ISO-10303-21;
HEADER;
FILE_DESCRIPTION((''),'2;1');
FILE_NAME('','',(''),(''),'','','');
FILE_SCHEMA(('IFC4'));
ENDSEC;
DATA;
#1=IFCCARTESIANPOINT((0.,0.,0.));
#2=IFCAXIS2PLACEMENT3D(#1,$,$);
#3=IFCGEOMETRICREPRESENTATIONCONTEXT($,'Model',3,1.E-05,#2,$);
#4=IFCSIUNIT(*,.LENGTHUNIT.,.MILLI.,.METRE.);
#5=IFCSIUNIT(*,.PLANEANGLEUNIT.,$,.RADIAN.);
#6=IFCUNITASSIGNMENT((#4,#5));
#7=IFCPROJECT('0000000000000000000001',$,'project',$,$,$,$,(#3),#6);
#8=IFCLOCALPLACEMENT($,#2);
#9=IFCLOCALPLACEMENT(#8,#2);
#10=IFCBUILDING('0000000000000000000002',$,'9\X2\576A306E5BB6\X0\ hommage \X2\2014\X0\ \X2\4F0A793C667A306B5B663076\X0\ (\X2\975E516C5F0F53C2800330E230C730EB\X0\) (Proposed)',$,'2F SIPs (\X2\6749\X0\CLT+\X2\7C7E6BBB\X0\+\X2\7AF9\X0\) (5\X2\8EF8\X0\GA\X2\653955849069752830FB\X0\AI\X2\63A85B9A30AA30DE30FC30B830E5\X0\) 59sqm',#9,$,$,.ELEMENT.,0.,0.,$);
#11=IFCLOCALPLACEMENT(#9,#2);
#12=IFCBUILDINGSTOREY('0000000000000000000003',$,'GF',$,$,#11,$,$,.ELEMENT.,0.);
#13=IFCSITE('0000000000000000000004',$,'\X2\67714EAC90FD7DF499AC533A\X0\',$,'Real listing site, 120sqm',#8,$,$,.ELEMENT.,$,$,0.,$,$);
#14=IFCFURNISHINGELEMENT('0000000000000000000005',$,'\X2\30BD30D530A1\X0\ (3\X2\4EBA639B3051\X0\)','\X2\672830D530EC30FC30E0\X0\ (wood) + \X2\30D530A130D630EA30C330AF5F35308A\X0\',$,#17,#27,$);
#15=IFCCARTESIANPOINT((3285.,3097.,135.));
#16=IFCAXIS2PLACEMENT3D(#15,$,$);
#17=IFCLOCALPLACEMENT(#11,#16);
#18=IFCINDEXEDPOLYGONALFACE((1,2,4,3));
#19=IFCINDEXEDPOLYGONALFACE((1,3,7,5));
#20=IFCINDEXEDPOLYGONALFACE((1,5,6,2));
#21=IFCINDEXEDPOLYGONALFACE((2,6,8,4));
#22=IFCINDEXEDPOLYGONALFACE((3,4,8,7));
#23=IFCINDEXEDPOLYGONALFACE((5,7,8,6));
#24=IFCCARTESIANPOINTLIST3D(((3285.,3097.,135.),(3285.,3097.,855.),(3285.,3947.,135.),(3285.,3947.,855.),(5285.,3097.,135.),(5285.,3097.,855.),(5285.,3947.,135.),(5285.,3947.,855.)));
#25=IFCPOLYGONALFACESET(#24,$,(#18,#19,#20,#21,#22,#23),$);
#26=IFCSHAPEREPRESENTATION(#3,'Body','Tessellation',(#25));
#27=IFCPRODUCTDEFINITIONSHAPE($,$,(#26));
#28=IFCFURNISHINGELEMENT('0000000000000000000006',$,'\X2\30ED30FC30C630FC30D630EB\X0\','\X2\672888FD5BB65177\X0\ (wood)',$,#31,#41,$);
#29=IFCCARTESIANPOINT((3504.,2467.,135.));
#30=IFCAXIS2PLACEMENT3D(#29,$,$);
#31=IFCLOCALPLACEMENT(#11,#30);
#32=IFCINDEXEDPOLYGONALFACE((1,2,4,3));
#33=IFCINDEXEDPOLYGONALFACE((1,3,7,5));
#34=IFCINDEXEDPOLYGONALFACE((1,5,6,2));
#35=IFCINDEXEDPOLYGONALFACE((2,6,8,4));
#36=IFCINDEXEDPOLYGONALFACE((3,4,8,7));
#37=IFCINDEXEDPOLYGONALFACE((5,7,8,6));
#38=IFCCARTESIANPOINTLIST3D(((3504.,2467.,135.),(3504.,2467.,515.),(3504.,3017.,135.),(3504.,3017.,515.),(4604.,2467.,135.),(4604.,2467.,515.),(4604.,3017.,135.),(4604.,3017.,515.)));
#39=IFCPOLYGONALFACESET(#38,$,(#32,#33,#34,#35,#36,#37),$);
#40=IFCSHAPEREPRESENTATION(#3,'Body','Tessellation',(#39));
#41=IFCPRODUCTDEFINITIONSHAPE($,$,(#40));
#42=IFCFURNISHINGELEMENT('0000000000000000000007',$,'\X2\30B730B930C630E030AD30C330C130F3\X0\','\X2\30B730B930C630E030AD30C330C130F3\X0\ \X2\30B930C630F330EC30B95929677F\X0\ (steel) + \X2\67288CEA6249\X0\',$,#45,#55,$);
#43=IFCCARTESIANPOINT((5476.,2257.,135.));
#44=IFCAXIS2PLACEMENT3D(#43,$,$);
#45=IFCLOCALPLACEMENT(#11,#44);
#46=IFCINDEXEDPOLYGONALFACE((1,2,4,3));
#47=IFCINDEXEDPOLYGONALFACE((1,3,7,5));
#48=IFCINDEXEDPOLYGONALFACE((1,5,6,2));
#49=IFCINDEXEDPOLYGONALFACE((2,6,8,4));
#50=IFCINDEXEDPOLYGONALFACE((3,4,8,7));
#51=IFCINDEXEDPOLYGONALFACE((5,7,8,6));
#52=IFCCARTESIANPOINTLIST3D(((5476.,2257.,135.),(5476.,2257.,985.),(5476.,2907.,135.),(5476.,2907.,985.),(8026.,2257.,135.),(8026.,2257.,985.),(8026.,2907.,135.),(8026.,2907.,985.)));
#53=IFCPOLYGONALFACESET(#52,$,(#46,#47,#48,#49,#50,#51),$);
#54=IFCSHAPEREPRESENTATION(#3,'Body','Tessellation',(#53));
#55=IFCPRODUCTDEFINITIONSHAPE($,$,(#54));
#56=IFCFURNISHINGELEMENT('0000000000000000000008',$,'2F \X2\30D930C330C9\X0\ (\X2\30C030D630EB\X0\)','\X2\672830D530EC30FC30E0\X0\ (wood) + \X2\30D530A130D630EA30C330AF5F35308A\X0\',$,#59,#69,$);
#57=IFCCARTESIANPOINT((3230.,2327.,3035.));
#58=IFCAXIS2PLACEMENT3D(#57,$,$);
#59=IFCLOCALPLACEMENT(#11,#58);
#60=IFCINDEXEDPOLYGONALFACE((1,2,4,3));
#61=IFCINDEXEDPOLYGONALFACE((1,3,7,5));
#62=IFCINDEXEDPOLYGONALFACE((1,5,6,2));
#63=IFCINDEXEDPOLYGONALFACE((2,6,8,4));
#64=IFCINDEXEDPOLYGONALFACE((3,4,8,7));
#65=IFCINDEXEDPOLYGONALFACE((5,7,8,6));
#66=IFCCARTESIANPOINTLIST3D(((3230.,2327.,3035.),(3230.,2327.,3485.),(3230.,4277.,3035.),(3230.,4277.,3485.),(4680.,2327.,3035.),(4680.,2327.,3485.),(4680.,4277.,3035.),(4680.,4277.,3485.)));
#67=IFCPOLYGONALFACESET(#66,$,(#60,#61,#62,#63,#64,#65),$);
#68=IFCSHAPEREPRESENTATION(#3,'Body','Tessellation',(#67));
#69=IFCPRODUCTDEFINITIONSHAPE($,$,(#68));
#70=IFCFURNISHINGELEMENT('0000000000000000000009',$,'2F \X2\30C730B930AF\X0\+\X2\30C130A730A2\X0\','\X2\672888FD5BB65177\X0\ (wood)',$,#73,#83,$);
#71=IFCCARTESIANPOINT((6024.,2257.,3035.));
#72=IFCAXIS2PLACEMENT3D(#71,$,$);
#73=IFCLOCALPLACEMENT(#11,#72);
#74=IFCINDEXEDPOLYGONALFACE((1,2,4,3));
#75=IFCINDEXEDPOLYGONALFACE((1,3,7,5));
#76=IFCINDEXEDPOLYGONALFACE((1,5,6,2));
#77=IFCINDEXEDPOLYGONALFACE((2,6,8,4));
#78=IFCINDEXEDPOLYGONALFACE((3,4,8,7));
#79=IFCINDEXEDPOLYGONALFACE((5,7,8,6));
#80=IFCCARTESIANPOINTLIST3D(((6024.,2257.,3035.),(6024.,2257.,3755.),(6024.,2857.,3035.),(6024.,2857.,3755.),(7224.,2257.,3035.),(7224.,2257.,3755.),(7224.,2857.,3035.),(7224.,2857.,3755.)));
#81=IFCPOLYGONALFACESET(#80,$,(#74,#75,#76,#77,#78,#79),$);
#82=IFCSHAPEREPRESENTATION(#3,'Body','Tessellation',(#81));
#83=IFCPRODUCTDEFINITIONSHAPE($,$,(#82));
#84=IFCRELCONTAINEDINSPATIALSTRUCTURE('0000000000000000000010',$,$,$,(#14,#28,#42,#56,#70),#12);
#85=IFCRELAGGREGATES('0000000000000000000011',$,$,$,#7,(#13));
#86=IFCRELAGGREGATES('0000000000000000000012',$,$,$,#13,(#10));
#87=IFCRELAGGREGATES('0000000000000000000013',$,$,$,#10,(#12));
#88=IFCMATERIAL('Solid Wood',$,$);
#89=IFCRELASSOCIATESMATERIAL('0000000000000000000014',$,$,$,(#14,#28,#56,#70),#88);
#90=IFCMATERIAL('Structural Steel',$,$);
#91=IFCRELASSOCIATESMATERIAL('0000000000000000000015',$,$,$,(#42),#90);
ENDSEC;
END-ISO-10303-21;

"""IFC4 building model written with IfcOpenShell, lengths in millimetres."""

from ifc_helpers import new_model, si_unit, frame, frame_2d, origin, place, context, project, spatial, rectangle, extrude, material, element, save


model = new_model("IFC4")

# Units and contexts
model_context = context("Model", 3, precision=1e-05, world=origin())
ifc_project = project(units=[si_unit("LENGTHUNIT", "METRE", prefix="MILLI"), si_unit("PLANEANGLEUNIT", "RADIAN")], contexts=[model_context])

# Site, building, storey
site_placement = place(None, origin())
site = spatial("IfcSite", under=ifc_project, at=site_placement, Name="東京都練馬区", ObjectType="Real listing site, 120sqm", CompositionType="ELEMENT", RefElevation=0.0)
building_placement = place(site_placement, origin())
building = spatial("IfcBuilding", under=site, at=building_placement, Name="9坪の家 hommage — 伊礼智に学ぶ (非公式参考モデル) (Proposed)", ObjectType="2F SIPs (杉CLT+籾殻+竹) (5軸GA改善適用・AI推定オマージュ) 59sqm", CompositionType="ELEMENT", ElevationOfRefHeight=0.0, ElevationOfTerrain=0.0)
storey_placement = place(building_placement, origin())
storey = spatial("IfcBuildingStorey", under=building, at=storey_placement, Name="GF", CompositionType="ELEMENT", Elevation=0.0)

# Shared definitions
ifc_material_1 = material(Name="Solid Wood")

# Shared definitions
ifc_material_2 = material(Name="Structural Steel")

# Furnishing elements
furnishing_1_placement = place(storey_placement, frame((3285.0, 3097.0, 135.0)))
element("IfcFurnishingElement", 1, at=furnishing_1_placement, inside=storey, material=ifc_material_1, Name="ソファ (3人掛け)", Description="木フレーム (wood) + ファブリック張り", context=model_context, shape_type="SweptSolid", body=[
    extrude(rectangle(XDim=2000.0, YDim=850.0, at=frame_2d((1000.0, 425.0))), frame((3285.0, 3097.0, 135.0)), (0.0, 0.0, 1.0), 720.0),
])
furnishing_2_placement = place(storey_placement, frame((3504.0, 2467.0, 135.0)))
element("IfcFurnishingElement", 2, at=furnishing_2_placement, inside=storey, material=ifc_material_1, Name="ローテーブル", Description="木製家具 (wood)", context=model_context, shape_type="SweptSolid", body=[
    extrude(rectangle(XDim=1100.0, YDim=550.0, at=frame_2d((550.0, 275.0))), frame((3504.0, 2467.0, 135.0)), (0.0, 0.0, 1.0), 380.0),
])
furnishing_3_placement = place(storey_placement, frame((5476.0, 2257.0, 135.0)))
element("IfcFurnishingElement", 3, at=furnishing_3_placement, inside=storey, material=ifc_material_2, Name="システムキッチン", Description="システムキッチン ステンレス天板 (steel) + 木質扉", context=model_context, shape_type="SweptSolid", body=[
    extrude(rectangle(XDim=2550.0, YDim=650.0, at=frame_2d((1275.0, 325.0))), frame((5476.0, 2257.0, 135.0)), (0.0, 0.0, 1.0), 850.0),
])
furnishing_4_placement = place(storey_placement, frame((3230.0, 2327.0, 3035.0)))
element("IfcFurnishingElement", 4, at=furnishing_4_placement, inside=storey, material=ifc_material_1, Name="2F ベッド (ダブル)", Description="木フレーム (wood) + ファブリック張り", context=model_context, shape_type="SweptSolid", body=[
    extrude(rectangle(XDim=1450.0, YDim=1950.0, at=frame_2d((725.0, 975.0))), frame((3230.0, 2327.0, 3035.0)), (0.0, 0.0, 1.0), 450.0),
])
furnishing_5_placement = place(storey_placement, frame((6024.0, 2257.0, 3035.0)))
element("IfcFurnishingElement", 5, at=furnishing_5_placement, inside=storey, material=ifc_material_1, Name="2F デスク+チェア", Description="木製家具 (wood)", context=model_context, shape_type="SweptSolid", body=[
    extrude(rectangle(XDim=1200.0, YDim=600.0, at=frame_2d((600.0, 300.0))), frame((6024.0, 2257.0, 3035.0)), (0.0, 0.0, 1.0), 720.0),
])

save(model, "model.ifc")
